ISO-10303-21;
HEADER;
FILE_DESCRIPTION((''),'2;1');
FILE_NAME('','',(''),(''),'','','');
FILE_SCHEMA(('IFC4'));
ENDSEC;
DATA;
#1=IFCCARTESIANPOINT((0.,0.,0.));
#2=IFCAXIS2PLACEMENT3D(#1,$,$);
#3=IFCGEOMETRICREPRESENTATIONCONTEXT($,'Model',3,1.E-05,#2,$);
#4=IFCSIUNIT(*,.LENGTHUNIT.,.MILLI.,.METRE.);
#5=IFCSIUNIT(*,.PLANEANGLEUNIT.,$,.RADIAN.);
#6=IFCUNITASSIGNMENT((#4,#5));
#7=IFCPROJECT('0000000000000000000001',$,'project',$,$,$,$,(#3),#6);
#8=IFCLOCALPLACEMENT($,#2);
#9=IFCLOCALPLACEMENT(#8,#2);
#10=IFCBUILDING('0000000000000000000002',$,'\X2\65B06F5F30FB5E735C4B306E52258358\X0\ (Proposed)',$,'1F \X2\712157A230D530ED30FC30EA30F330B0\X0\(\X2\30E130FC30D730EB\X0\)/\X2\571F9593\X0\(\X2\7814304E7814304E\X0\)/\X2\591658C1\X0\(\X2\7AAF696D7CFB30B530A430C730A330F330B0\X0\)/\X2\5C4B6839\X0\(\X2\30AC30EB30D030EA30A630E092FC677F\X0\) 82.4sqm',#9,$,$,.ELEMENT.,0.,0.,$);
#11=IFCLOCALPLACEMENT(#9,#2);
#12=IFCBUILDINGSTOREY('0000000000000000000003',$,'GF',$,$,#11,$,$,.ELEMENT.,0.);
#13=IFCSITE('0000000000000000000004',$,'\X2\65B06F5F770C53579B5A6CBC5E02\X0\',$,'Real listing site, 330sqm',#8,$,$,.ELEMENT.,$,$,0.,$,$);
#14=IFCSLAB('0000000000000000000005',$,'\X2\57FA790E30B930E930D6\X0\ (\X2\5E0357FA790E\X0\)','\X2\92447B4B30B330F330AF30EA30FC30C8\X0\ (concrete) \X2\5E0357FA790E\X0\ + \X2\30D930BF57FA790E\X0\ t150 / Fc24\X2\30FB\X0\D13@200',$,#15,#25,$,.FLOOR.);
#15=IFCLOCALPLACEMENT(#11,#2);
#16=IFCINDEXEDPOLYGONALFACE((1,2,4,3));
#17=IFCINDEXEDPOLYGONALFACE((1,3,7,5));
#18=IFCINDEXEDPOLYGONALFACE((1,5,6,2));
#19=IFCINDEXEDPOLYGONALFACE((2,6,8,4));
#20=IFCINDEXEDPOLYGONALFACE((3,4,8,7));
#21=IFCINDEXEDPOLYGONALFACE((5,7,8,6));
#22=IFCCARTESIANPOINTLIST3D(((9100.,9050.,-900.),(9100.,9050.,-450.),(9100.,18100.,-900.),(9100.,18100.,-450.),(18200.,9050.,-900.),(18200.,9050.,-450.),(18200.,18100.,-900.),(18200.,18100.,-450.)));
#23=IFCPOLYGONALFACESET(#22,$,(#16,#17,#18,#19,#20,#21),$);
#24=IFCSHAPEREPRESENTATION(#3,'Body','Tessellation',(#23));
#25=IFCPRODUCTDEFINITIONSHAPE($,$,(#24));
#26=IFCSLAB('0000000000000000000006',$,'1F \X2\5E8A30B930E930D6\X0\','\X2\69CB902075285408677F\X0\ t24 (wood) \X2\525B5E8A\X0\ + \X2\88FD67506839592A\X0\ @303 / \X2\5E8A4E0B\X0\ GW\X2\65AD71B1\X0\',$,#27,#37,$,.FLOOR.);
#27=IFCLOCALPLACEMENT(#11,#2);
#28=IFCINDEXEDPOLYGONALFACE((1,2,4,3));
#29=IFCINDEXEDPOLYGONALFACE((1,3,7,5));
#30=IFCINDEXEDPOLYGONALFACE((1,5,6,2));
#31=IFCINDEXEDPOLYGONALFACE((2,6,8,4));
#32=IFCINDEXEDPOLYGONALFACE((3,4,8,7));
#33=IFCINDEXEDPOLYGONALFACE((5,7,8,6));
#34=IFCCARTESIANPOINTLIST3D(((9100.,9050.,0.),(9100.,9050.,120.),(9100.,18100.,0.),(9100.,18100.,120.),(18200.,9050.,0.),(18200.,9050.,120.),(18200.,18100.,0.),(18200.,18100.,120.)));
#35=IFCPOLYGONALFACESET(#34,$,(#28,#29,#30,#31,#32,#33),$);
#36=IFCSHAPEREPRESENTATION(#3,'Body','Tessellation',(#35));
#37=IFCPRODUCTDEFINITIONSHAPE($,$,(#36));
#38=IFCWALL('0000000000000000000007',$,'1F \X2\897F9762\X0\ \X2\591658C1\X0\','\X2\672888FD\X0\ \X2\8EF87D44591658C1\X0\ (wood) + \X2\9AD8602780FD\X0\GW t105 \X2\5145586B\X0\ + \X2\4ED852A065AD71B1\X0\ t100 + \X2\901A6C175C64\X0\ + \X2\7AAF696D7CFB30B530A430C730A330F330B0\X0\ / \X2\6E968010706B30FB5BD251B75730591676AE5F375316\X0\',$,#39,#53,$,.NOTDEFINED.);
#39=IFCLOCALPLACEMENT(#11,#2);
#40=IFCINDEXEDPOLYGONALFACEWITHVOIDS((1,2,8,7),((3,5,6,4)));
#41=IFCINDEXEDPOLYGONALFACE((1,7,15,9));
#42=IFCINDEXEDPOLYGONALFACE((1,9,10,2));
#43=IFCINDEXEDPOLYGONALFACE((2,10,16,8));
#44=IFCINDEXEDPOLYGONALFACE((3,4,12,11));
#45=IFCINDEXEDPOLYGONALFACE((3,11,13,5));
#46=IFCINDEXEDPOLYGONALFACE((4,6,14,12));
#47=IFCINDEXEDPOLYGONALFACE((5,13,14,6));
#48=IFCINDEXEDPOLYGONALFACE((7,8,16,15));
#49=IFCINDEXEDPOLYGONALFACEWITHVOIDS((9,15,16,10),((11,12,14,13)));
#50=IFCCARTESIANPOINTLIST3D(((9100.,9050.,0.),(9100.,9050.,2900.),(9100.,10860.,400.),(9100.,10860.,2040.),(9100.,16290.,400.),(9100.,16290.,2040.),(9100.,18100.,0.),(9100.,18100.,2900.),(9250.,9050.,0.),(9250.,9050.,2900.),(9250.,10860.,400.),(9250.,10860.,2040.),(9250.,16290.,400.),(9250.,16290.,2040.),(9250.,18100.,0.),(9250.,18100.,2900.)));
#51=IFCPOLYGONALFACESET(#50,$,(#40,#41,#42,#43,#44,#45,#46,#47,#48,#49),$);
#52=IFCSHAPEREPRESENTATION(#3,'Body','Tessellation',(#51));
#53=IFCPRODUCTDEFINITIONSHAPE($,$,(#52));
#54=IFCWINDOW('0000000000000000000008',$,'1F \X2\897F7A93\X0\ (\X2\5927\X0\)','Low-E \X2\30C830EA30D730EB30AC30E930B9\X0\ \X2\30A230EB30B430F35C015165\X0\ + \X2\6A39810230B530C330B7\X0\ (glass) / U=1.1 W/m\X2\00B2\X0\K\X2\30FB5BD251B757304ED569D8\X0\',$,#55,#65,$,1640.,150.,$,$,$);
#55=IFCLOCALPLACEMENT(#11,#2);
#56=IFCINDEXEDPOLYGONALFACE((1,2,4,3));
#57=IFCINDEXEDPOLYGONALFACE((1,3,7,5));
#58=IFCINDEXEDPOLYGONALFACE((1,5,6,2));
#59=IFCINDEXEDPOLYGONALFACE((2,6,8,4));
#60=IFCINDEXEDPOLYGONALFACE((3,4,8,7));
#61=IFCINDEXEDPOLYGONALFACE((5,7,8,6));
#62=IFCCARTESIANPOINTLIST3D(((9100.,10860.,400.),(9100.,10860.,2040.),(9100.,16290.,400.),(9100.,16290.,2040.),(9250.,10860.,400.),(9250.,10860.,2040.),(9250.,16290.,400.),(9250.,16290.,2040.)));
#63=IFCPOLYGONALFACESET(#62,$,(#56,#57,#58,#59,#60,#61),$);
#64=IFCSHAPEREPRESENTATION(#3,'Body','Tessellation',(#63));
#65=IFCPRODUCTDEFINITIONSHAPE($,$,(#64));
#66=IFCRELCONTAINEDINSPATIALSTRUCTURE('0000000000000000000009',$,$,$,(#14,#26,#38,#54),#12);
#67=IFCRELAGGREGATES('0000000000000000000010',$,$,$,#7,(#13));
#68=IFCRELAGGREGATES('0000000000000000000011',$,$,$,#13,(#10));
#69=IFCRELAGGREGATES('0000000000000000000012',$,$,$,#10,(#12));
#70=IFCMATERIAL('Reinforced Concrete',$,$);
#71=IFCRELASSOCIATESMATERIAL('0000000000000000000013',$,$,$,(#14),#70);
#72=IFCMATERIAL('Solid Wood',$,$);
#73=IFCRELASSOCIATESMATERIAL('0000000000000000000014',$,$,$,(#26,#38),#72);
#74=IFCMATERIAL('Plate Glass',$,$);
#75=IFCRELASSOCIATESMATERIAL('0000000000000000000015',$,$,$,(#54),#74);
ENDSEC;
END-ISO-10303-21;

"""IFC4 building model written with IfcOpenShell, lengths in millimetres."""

from ifc_helpers import new_model, si_unit, frame, frame_2d, origin, place, context, project, spatial, rectangle, extrude, material, element, fill, save


model = new_model("IFC4")

# Units and contexts
model_context = context("Model", 3, precision=1e-05, world=origin())
ifc_project = project(units=[si_unit("LENGTHUNIT", "METRE", prefix="MILLI"), si_unit("PLANEANGLEUNIT", "RADIAN")], contexts=[model_context])

# Site, building, storey
site_placement = place(None, origin())
site = spatial("IfcSite", under=ifc_project, at=site_placement, Name="新潟県南魚沼市", ObjectType="Real listing site, 330sqm", CompositionType="ELEMENT", RefElevation=0.0)
building_placement = place(site_placement, origin())
building = spatial("IfcBuilding", under=site, at=building_placement, Name="新潟・平屋の別荘 (Proposed)", ObjectType="1F 無垢フローリング(メープル)/土間(研ぎ研ぎ)/外壁(窯業系サイディング)/屋根(ガルバリウム鋼板) 82.4sqm", CompositionType="ELEMENT", ElevationOfRefHeight=0.0, ElevationOfTerrain=0.0)
storey_placement = place(building_placement, origin())
storey = spatial("IfcBuildingStorey", under=building, at=storey_placement, Name="GF", CompositionType="ELEMENT", Elevation=0.0)

# Shared definitions
ifc_material_1 = material(Name="Solid Wood")

# Slabs
ifc_material_2 = material(Name="Reinforced Concrete")
slab_1_placement = place(storey_placement, frame((4550.0, 4525.0, -450.0)))
element("IfcSlab", 1, at=slab_1_placement, inside=storey, material=ifc_material_2, Name="基礎スラブ (布基礎)", Description="鉄筋コンクリート (concrete) 布基礎 + ベタ基礎 t150 / Fc24・D13@200", PredefinedType="FLOOR", context=model_context, shape_type="SweptSolid", body=[
    extrude(rectangle(XDim=9100.0, YDim=9050.0, at=frame_2d((4550.0, 4525.0))), frame((4550.0, 4525.0, -450.0)), (0.0, 0.0, 1.0), 450.0),
])
slab_2_placement = place(storey_placement, frame((4550.0, 4525.0, 0.0)))
element("IfcSlab", 2, at=slab_2_placement, inside=storey, material=ifc_material_1, Name="1F 床スラブ", Description="構造用合板 t24 (wood) 剛床 + 製材根太 @303 / 床下 GW断熱", PredefinedType="FLOOR", context=model_context, shape_type="SweptSolid", body=[
    extrude(rectangle(XDim=9100.0, YDim=9050.0, at=frame_2d((4550.0, 4525.0))), frame((4550.0, 4525.0, 0.0)), (0.0, 0.0, 1.0), 120.0),
])

# Shared definitions
ifc_material_3 = material(Name="Plate Glass")

# Wall, opening, window
wall_1_placement = place(storey_placement, frame((4550.0, 4525.0, 0.0)))
wall_1 = element("IfcWall", 3, at=wall_1_placement, inside=storey, material=ifc_material_1, Name="1F 西面 外壁", Description="木製 軸組外壁 (wood) + 高性能GW t105 充填 + 付加断熱 t100 + 通気層 + 窯業系サイディング / 準耐火・寒冷地外皮強化", PredefinedType="NOTDEFINED", context=model_context, shape_type="SweptSolid", body=[
    extrude(rectangle(XDim=150.0, YDim=9050.0, at=frame_2d((75.0, 4525.0))), frame((4550.0, 4525.0, 0.0)), (0.0, 0.0, 1.0), 2900.0),
])
opening_1_placement = place(storey_placement, frame((4550.0, 5430.0, 200.0)))
opening_1 = element("IfcOpeningElement", 4, at=opening_1_placement, cuts=wall_1, PredefinedType="NOTDEFINED", context=model_context, shape_type="SweptSolid", body=[
    extrude(rectangle(XDim=150.0, YDim=5430.0, at=frame_2d((75.0, 2715.0))), frame((4550.0, 5430.0, 200.0)), (0.0, 0.0, 1.0), 1640.0),
])
window_1_placement = place(storey_placement, frame((4550.0, 5430.0, 200.0)))
window_1 = element("IfcWindow", 5, at=window_1_placement, inside=storey, material=ifc_material_3, Name="1F 西窓 (大)", Description="Low-E トリプルガラス アルゴン封入 + 樹脂サッシ (glass) / U=1.1 W/m²K・寒冷地仕様", OverallHeight=1640.0, OverallWidth=150.0, context=model_context, shape_type="SweptSolid", body=[
    extrude(rectangle(XDim=150.0, YDim=5430.0, at=frame_2d((75.0, 2715.0))), frame((4550.0, 5430.0, 200.0)), (0.0, 0.0, 1.0), 1640.0),
])
fill(opening_1, window_1)

save(model, "model.ifc")
